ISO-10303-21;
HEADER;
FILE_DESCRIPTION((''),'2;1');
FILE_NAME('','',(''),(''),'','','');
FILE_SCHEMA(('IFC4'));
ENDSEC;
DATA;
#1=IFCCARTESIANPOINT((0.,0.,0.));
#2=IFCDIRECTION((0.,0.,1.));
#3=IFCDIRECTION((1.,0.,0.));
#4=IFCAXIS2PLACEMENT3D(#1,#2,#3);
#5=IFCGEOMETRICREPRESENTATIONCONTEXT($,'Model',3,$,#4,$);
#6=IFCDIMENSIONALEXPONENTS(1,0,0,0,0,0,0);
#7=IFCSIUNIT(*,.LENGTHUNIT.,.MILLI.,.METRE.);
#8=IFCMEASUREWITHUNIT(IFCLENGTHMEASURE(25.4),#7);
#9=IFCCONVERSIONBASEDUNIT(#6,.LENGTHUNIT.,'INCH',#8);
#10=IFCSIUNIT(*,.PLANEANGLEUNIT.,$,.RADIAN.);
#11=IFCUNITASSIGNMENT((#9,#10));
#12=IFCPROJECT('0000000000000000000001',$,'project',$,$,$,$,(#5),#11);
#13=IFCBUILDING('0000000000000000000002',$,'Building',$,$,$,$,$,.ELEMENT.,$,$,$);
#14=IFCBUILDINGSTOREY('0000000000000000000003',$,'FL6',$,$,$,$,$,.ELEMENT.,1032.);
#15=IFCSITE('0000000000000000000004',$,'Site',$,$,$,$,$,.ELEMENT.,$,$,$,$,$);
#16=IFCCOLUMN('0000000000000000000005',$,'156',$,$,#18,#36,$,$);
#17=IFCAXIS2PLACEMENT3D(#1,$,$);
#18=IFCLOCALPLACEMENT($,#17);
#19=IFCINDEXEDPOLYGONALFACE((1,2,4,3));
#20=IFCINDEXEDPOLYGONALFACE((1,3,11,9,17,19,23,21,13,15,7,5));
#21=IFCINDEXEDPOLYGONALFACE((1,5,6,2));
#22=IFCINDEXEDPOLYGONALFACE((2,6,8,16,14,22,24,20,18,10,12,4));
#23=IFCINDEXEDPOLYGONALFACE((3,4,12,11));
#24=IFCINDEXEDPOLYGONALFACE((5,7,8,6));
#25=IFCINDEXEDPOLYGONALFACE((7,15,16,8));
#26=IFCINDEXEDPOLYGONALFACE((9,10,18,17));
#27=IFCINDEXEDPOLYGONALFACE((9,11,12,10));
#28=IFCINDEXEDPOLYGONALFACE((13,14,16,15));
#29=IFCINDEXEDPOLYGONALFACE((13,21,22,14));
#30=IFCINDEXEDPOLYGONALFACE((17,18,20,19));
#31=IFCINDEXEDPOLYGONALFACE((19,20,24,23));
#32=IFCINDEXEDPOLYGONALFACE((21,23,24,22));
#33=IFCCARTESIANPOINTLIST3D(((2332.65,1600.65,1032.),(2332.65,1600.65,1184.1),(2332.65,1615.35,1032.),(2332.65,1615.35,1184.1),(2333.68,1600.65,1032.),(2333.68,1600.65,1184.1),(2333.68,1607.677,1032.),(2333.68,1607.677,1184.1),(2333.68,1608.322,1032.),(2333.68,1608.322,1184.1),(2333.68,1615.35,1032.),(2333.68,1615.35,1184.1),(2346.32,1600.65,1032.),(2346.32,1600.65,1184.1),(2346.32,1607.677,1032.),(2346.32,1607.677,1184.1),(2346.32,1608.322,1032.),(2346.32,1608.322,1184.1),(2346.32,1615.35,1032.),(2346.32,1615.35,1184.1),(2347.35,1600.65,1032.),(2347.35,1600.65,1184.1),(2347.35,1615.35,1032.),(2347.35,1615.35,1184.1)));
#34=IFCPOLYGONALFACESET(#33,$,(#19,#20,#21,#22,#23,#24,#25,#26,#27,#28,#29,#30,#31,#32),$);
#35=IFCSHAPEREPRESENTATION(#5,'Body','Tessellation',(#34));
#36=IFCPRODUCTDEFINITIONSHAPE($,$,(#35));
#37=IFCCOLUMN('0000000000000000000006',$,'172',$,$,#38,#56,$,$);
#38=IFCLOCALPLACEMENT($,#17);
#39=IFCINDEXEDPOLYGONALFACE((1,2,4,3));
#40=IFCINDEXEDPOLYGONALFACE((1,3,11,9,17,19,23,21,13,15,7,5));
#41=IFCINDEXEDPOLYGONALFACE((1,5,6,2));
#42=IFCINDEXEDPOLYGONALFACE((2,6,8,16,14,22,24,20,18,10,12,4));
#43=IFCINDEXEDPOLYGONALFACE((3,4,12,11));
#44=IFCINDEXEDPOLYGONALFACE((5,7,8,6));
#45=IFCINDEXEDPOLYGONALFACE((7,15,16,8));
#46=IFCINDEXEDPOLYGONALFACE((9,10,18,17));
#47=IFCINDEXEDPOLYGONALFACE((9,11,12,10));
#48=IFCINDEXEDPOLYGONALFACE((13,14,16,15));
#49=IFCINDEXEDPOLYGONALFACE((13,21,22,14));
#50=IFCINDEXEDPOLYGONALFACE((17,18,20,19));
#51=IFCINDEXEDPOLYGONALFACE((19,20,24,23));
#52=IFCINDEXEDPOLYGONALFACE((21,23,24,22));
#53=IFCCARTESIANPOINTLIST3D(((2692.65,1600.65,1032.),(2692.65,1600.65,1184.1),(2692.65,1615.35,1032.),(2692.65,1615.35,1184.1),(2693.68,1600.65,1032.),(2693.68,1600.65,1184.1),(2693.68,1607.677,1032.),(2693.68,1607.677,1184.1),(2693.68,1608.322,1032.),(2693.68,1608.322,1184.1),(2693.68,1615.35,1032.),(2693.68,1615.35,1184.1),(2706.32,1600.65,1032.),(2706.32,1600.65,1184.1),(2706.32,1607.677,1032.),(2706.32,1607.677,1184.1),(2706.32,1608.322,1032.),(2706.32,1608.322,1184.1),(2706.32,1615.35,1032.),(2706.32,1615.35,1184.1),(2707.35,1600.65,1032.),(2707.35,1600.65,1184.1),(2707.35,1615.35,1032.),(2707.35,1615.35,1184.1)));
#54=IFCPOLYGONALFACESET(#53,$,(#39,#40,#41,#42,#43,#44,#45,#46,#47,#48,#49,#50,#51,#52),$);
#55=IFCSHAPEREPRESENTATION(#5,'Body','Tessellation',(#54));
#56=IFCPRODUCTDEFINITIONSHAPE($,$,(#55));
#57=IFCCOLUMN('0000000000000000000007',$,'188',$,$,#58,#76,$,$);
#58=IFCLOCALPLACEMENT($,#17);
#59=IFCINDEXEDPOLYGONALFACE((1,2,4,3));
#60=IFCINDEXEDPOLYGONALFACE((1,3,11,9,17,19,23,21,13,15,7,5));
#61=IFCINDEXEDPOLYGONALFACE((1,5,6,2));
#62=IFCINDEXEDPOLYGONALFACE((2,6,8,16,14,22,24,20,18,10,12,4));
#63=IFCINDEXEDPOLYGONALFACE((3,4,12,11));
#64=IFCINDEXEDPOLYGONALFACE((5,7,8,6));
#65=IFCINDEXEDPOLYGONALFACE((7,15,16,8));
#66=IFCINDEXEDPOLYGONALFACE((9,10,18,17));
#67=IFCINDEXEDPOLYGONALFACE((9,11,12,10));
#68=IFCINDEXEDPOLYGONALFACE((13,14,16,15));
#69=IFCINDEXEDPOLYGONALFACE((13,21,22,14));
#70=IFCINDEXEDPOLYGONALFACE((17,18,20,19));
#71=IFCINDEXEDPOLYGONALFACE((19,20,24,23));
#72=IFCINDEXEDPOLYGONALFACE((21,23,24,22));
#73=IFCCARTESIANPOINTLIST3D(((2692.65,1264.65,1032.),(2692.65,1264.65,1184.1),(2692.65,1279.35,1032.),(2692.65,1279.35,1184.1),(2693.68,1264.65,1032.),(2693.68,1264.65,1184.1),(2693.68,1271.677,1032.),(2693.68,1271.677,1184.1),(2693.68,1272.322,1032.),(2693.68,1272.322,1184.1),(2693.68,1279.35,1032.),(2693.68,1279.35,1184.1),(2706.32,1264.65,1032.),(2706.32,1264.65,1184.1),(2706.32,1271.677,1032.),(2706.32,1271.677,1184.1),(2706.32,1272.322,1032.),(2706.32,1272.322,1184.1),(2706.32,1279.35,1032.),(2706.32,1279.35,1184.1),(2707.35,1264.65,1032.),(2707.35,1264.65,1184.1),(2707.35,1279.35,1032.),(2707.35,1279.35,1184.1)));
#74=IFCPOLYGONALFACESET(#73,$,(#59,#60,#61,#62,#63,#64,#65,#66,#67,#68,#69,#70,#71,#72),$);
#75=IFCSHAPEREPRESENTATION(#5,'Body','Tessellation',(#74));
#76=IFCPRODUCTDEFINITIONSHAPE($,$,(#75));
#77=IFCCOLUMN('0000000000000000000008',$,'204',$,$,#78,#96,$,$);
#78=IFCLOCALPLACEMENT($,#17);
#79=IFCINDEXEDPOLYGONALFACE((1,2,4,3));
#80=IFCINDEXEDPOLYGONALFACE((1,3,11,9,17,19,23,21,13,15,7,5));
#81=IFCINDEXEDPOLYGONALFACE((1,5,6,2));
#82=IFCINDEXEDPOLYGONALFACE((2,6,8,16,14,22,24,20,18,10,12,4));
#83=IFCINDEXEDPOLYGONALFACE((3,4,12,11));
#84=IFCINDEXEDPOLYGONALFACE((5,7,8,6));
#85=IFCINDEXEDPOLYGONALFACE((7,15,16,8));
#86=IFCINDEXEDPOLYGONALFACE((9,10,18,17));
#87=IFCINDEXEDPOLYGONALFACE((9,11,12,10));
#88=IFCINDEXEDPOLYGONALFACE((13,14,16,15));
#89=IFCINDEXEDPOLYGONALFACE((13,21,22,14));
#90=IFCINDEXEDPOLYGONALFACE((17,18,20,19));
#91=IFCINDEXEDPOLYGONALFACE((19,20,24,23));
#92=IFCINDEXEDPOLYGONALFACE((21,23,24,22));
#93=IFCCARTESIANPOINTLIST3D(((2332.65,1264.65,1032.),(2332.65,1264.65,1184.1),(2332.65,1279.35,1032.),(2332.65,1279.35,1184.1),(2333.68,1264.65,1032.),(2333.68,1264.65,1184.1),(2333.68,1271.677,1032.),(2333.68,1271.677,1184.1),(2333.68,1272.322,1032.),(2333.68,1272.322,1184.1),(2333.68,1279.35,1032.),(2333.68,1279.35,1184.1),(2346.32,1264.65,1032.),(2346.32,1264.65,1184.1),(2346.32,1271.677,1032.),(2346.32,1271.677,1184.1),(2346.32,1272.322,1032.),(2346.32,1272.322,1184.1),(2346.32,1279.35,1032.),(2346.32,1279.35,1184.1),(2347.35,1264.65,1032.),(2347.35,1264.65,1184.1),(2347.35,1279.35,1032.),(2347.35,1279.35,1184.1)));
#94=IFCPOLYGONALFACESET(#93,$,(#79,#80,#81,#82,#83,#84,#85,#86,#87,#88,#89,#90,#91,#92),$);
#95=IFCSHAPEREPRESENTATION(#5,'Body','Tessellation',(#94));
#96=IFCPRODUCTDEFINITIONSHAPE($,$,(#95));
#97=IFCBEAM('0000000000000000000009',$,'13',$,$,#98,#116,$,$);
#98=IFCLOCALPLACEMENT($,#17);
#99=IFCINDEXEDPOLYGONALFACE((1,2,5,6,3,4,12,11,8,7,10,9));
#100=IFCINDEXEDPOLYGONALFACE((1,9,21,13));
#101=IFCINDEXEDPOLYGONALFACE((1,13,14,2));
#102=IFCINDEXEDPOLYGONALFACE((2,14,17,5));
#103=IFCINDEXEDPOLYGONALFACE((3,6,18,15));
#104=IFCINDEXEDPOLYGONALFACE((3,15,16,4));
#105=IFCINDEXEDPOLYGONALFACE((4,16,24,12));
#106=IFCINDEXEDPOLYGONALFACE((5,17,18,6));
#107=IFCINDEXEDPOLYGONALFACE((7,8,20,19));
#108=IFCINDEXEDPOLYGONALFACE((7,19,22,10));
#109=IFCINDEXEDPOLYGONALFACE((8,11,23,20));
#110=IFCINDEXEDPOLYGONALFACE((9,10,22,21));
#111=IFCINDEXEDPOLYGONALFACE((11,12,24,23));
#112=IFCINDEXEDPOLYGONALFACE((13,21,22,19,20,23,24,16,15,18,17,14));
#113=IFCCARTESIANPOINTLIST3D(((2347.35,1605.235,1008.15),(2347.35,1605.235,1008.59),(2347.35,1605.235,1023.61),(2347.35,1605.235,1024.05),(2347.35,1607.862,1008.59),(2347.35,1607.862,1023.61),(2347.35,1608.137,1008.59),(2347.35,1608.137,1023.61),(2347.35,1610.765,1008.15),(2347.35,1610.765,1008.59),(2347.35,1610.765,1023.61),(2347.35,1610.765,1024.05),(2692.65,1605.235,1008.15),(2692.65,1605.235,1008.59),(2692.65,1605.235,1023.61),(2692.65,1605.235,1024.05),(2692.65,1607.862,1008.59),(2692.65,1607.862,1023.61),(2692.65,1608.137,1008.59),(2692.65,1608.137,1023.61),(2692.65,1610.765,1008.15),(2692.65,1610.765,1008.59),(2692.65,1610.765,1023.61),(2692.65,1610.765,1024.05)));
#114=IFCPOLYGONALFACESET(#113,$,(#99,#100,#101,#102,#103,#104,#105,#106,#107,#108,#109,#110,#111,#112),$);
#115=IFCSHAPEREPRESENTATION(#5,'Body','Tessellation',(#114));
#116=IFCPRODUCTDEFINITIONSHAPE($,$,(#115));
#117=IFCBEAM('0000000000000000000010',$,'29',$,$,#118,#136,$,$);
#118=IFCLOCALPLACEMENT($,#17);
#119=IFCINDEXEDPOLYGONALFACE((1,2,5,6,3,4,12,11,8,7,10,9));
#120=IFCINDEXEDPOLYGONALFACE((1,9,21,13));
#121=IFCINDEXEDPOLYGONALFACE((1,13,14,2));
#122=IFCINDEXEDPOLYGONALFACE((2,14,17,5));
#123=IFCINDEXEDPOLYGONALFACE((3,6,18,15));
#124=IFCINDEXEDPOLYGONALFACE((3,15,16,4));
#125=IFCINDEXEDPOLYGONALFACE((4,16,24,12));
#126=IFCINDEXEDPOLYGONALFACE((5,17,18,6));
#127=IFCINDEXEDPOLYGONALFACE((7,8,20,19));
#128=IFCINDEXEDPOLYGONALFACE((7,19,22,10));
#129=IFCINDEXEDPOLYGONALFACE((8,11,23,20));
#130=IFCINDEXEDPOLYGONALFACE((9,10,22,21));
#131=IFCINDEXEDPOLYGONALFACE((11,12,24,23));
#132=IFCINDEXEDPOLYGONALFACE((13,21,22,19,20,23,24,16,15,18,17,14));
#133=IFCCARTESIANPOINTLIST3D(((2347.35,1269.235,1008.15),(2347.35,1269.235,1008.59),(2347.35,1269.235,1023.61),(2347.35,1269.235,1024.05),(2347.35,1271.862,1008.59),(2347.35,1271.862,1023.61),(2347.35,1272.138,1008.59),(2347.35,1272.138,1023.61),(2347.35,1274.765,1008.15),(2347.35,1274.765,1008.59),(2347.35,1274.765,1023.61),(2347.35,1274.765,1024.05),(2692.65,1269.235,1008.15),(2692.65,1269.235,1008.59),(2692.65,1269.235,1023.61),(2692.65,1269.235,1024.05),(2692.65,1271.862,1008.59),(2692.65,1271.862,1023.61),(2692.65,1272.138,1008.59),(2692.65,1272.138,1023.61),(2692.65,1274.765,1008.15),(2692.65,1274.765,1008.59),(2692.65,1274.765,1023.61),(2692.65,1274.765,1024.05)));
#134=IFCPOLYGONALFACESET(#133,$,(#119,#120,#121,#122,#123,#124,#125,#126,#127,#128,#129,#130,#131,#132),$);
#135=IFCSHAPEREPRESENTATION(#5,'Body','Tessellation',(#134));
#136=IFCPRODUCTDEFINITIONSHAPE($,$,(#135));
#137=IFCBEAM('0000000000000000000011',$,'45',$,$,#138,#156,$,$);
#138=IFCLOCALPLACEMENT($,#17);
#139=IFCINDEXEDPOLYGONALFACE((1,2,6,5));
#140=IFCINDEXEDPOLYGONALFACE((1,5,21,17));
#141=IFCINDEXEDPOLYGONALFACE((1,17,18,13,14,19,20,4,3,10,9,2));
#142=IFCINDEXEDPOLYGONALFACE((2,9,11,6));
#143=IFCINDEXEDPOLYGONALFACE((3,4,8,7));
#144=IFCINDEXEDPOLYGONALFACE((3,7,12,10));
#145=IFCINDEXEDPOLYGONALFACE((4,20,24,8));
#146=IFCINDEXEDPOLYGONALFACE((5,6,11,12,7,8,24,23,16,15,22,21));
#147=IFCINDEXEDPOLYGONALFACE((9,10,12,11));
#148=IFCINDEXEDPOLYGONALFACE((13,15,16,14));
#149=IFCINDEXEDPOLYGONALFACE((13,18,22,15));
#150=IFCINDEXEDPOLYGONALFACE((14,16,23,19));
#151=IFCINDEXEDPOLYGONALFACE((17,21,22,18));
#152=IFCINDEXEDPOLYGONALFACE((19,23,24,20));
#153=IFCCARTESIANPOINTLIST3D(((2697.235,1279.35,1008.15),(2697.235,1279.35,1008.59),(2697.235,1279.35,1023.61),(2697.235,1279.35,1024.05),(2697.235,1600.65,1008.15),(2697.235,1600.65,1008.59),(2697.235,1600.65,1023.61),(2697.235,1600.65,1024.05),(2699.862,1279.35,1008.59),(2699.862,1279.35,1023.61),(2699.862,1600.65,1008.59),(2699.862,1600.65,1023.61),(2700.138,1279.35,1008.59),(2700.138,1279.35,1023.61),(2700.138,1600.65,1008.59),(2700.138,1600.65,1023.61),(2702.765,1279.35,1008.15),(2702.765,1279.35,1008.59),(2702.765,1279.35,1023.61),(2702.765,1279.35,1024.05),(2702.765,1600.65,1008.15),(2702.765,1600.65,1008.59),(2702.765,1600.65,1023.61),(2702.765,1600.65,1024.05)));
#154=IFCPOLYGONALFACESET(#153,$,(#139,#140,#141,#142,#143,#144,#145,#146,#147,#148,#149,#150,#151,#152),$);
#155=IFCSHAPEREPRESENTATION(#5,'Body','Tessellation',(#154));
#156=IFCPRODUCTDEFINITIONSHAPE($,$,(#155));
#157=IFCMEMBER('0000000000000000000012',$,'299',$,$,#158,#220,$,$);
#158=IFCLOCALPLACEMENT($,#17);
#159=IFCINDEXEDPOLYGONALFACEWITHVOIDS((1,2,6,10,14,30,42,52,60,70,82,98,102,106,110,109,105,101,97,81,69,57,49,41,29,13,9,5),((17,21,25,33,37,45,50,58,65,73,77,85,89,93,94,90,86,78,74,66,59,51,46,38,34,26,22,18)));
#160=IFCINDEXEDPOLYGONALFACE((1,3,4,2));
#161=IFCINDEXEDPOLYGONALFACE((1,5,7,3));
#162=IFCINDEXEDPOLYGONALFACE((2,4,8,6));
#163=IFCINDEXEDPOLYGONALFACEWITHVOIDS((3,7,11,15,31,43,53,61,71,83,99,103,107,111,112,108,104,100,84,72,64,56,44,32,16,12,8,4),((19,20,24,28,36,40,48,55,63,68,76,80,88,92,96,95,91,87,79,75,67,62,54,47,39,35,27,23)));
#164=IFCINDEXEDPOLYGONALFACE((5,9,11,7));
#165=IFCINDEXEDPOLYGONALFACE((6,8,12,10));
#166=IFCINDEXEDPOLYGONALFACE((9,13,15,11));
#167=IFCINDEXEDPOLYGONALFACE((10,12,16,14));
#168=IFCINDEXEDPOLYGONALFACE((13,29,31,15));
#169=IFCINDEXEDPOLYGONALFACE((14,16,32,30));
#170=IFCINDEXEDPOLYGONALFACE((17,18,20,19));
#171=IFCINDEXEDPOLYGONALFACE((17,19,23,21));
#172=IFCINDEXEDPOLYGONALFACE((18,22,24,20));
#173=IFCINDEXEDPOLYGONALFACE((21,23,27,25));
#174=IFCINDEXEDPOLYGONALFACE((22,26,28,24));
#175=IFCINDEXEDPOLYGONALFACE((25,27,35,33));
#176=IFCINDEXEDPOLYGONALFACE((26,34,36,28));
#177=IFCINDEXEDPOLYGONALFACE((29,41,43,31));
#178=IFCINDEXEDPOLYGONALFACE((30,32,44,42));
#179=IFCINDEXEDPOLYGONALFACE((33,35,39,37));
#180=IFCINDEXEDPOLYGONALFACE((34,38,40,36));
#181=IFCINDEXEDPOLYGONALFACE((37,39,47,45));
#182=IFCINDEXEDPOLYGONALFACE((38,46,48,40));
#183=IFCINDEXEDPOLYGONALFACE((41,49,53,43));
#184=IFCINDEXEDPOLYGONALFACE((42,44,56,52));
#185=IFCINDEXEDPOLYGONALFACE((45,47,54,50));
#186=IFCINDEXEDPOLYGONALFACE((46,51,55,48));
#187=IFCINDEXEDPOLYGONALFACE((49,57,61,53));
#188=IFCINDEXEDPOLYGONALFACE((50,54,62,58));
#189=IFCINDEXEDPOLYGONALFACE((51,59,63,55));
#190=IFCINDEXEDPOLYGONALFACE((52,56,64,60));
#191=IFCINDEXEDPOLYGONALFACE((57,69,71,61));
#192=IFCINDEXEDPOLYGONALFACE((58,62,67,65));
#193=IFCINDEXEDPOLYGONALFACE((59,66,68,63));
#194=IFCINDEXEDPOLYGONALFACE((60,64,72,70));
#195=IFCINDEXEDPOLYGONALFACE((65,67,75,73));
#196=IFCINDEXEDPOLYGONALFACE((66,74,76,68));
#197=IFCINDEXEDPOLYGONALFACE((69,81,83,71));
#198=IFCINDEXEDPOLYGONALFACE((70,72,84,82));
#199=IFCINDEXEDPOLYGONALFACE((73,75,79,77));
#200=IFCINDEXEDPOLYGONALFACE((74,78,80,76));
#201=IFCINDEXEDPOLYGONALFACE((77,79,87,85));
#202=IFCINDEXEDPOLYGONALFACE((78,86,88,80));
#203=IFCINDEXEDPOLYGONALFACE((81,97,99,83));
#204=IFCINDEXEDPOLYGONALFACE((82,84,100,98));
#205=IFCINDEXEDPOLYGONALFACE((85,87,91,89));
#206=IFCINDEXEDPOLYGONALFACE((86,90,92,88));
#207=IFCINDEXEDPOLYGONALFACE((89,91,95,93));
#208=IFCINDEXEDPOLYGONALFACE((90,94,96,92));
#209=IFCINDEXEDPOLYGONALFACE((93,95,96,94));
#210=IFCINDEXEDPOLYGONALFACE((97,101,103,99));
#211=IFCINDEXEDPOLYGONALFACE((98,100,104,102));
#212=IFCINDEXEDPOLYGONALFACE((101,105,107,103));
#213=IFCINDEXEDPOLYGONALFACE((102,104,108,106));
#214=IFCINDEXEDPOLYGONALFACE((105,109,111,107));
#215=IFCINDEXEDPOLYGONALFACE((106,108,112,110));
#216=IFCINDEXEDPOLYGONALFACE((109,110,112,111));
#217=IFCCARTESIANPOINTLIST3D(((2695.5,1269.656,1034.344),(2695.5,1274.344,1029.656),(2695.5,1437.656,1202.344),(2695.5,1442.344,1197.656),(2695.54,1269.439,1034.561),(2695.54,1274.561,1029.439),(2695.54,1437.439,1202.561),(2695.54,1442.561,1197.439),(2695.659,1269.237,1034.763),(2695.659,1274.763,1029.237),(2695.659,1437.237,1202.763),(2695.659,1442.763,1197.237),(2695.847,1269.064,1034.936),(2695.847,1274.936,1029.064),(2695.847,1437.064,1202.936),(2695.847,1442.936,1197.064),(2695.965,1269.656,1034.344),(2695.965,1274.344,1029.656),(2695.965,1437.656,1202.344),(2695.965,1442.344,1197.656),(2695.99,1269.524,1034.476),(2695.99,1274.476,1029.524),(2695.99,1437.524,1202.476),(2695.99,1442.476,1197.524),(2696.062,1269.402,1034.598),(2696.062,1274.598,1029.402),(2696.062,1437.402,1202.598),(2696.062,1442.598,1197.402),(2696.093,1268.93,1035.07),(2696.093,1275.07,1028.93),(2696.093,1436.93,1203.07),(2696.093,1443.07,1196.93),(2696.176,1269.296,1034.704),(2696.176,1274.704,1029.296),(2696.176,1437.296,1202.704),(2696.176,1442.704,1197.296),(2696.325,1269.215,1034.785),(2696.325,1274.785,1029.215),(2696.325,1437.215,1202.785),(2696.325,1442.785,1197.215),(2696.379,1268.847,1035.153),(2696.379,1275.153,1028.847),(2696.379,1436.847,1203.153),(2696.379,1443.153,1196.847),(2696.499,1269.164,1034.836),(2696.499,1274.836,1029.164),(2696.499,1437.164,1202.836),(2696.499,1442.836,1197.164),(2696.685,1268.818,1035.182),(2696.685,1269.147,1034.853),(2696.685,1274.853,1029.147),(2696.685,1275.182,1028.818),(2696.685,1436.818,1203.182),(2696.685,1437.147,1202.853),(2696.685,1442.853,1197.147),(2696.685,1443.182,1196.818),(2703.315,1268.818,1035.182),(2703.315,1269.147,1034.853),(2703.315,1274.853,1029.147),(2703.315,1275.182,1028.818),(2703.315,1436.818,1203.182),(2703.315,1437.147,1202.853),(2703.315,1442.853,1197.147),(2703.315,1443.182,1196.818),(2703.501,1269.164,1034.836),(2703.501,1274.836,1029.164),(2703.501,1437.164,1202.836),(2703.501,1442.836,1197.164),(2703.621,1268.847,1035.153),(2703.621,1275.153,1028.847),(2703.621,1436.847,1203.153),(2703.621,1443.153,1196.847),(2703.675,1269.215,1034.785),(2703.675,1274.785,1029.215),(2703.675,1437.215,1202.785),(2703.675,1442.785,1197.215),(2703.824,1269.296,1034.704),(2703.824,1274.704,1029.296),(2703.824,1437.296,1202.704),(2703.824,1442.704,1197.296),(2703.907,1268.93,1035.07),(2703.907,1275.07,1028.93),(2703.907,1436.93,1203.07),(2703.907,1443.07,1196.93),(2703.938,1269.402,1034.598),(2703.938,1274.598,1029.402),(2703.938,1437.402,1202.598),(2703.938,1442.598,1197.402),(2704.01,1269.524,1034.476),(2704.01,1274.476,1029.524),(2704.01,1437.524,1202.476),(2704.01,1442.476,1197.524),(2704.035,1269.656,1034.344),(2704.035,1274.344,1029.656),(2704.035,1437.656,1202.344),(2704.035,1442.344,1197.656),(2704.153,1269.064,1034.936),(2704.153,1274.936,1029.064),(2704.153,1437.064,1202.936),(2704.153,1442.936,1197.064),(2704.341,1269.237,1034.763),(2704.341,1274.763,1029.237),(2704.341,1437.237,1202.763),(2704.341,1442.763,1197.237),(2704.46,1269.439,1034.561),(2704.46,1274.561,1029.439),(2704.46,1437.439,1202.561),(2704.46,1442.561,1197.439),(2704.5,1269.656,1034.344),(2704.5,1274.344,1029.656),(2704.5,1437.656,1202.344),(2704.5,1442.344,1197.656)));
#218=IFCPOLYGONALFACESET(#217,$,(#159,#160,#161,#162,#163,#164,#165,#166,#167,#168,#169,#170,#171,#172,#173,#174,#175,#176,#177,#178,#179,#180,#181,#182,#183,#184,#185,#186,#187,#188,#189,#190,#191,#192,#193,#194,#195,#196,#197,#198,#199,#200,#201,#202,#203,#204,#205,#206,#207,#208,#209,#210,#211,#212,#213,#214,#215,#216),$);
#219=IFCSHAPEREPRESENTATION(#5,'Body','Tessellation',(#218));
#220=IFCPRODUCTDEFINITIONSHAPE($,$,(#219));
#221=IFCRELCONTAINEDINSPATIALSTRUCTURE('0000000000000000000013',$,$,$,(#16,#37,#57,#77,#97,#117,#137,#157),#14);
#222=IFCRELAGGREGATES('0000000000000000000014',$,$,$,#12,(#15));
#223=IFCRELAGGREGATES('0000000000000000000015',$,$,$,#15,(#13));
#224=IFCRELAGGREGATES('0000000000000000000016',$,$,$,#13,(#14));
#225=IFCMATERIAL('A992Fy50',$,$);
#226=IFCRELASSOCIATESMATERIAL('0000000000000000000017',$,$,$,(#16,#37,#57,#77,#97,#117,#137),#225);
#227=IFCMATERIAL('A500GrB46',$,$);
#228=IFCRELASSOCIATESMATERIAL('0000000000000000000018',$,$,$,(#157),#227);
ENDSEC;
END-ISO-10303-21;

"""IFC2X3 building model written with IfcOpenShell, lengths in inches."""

from ifc_helpers import new_model, entity, si_unit, converted_unit, frame, origin_with_axes, origin_2d_with_axis, place, context, project, spatial, hollow_rectangle, i_section, transform_2d, derived_profile, extrude, material, element, save


model = new_model("IFC2X3")

# Units and contexts
model_context = context("Model", 3, world=origin_with_axes())
ifc_project = project(units=[converted_unit("LENGTHUNIT", "INCH", entity("IfcLengthMeasure", 25.4), si_unit("LENGTHUNIT", "METRE", prefix="MILLI"), dimensions=[1, 0, 0, 0, 0, 0, 0]), si_unit("PLANEANGLEUNIT", "RADIAN")], contexts=[model_context])

# Site, building, storey
site = spatial("IfcSite", under=ifc_project, Name="Site", CompositionType="ELEMENT")
building = spatial("IfcBuilding", under=site, Name="Building", CompositionType="ELEMENT")
storey = spatial("IfcBuildingStorey", under=building, Name="FL6", CompositionType="ELEMENT", Elevation=1032.0)

# Columns
ifc_material_1 = material(Name="A992Fy50")
for number, where, z_axis, x_axis, name in (
    (1, (2340.0, 1608.0, 1032.0), (0.0, 0.0, 1.0), (0.0, -1.0, 0.0), "156"),
    (2, (2700.0, 1608.0, 1032.0), (0.0, 0.0, 1.0), (0.0, -1.0, 0.0), "172"),
    (3, (2700.0, 1272.0, 1032.0), (0.0, 0.0, 1.0), (0.0, -1.0, 0.0), "188"),
    (4, (2340.0, 1272.0, 1032.0), (0.0, 0.0, 1.0), (0.0, -1.0, 0.0), "204"),
):
    element("IfcColumn", number, at=place(None, frame(where, z_axis=z_axis, x_axis=x_axis)), inside=storey, material=ifc_material_1, Name=name, context=model_context, shape_type="SweptSolid", body=[
        extrude(i_section(OverallWidth=14.7, OverallDepth=14.7, WebThickness=0.645, FlangeThickness=1.03, at=origin_2d_with_axis()), origin_with_axes(), (0.0, 0.0, 1.0), 152.1),
    ])

# Beams
for number, where, z_axis, x_axis, name in (
    (5, (2347.35, 1608.0, 1032.0), (1.0, 0.0, 0.0), (0.0, 1.0, 0.0), "13"),
    (6, (2347.35, 1272.0, 1032.0), (1.0, 0.0, 0.0), (0.0, 1.0, 0.0), "29"),
):
    element("IfcBeam", number, at=place(None, frame(where, z_axis=z_axis, x_axis=x_axis)), inside=storey, material=ifc_material_1, Name=name, context=model_context, shape_type="SweptSolid", body=[
        extrude(derived_profile(i_section(OverallWidth=5.53, OverallDepth=15.9, WebThickness=0.275, FlangeThickness=0.44, at=origin_2d_with_axis()), transform_2d((0.0, -7.95))), origin_with_axes(), (0.0, 0.0, 1.0), 345.3),
    ])
beam_placement = place(None, frame((2700.0, 1279.35, 1032.0), z_axis=(0.0, 1.0, 0.0), x_axis=(-1.0, 0.0, 0.0)))
element("IfcBeam", 7, at=beam_placement, inside=storey, material=ifc_material_1, Name="45", context=model_context, shape_type="SweptSolid", body=[
    extrude(derived_profile(i_section(OverallWidth=5.53, OverallDepth=15.9, WebThickness=0.275, FlangeThickness=0.44, at=origin_2d_with_axis()), transform_2d((0.0, -7.95))), origin_with_axes(), (0.0, 0.0, 1.0), 321.3),
])

# Member
ifc_material_2 = material(Name="A500GrB46")
for number, where, z_axis, x_axis, name in (
    (8, (2700.0, 1272.0, 1032.0), (0.0, 0.707107, 0.707107), (-1.0, 0.0, 0.0), "299"),
):
    element("IfcMember", number, at=place(None, frame(where, z_axis=z_axis, x_axis=x_axis)), inside=storey, material=ifc_material_2, Name=name, context=model_context, shape_type="SweptSolid", body=[
        extrude(hollow_rectangle(XDim=9.0, YDim=9.0, WallThickness=0.465, InnerFilletRadius=0.72, OuterFilletRadius=1.185, at=origin_2d_with_axis()), origin_with_axes(), (0.0, 0.0, 1.0), 237.588),
    ])

save(model, "model.ifc")
